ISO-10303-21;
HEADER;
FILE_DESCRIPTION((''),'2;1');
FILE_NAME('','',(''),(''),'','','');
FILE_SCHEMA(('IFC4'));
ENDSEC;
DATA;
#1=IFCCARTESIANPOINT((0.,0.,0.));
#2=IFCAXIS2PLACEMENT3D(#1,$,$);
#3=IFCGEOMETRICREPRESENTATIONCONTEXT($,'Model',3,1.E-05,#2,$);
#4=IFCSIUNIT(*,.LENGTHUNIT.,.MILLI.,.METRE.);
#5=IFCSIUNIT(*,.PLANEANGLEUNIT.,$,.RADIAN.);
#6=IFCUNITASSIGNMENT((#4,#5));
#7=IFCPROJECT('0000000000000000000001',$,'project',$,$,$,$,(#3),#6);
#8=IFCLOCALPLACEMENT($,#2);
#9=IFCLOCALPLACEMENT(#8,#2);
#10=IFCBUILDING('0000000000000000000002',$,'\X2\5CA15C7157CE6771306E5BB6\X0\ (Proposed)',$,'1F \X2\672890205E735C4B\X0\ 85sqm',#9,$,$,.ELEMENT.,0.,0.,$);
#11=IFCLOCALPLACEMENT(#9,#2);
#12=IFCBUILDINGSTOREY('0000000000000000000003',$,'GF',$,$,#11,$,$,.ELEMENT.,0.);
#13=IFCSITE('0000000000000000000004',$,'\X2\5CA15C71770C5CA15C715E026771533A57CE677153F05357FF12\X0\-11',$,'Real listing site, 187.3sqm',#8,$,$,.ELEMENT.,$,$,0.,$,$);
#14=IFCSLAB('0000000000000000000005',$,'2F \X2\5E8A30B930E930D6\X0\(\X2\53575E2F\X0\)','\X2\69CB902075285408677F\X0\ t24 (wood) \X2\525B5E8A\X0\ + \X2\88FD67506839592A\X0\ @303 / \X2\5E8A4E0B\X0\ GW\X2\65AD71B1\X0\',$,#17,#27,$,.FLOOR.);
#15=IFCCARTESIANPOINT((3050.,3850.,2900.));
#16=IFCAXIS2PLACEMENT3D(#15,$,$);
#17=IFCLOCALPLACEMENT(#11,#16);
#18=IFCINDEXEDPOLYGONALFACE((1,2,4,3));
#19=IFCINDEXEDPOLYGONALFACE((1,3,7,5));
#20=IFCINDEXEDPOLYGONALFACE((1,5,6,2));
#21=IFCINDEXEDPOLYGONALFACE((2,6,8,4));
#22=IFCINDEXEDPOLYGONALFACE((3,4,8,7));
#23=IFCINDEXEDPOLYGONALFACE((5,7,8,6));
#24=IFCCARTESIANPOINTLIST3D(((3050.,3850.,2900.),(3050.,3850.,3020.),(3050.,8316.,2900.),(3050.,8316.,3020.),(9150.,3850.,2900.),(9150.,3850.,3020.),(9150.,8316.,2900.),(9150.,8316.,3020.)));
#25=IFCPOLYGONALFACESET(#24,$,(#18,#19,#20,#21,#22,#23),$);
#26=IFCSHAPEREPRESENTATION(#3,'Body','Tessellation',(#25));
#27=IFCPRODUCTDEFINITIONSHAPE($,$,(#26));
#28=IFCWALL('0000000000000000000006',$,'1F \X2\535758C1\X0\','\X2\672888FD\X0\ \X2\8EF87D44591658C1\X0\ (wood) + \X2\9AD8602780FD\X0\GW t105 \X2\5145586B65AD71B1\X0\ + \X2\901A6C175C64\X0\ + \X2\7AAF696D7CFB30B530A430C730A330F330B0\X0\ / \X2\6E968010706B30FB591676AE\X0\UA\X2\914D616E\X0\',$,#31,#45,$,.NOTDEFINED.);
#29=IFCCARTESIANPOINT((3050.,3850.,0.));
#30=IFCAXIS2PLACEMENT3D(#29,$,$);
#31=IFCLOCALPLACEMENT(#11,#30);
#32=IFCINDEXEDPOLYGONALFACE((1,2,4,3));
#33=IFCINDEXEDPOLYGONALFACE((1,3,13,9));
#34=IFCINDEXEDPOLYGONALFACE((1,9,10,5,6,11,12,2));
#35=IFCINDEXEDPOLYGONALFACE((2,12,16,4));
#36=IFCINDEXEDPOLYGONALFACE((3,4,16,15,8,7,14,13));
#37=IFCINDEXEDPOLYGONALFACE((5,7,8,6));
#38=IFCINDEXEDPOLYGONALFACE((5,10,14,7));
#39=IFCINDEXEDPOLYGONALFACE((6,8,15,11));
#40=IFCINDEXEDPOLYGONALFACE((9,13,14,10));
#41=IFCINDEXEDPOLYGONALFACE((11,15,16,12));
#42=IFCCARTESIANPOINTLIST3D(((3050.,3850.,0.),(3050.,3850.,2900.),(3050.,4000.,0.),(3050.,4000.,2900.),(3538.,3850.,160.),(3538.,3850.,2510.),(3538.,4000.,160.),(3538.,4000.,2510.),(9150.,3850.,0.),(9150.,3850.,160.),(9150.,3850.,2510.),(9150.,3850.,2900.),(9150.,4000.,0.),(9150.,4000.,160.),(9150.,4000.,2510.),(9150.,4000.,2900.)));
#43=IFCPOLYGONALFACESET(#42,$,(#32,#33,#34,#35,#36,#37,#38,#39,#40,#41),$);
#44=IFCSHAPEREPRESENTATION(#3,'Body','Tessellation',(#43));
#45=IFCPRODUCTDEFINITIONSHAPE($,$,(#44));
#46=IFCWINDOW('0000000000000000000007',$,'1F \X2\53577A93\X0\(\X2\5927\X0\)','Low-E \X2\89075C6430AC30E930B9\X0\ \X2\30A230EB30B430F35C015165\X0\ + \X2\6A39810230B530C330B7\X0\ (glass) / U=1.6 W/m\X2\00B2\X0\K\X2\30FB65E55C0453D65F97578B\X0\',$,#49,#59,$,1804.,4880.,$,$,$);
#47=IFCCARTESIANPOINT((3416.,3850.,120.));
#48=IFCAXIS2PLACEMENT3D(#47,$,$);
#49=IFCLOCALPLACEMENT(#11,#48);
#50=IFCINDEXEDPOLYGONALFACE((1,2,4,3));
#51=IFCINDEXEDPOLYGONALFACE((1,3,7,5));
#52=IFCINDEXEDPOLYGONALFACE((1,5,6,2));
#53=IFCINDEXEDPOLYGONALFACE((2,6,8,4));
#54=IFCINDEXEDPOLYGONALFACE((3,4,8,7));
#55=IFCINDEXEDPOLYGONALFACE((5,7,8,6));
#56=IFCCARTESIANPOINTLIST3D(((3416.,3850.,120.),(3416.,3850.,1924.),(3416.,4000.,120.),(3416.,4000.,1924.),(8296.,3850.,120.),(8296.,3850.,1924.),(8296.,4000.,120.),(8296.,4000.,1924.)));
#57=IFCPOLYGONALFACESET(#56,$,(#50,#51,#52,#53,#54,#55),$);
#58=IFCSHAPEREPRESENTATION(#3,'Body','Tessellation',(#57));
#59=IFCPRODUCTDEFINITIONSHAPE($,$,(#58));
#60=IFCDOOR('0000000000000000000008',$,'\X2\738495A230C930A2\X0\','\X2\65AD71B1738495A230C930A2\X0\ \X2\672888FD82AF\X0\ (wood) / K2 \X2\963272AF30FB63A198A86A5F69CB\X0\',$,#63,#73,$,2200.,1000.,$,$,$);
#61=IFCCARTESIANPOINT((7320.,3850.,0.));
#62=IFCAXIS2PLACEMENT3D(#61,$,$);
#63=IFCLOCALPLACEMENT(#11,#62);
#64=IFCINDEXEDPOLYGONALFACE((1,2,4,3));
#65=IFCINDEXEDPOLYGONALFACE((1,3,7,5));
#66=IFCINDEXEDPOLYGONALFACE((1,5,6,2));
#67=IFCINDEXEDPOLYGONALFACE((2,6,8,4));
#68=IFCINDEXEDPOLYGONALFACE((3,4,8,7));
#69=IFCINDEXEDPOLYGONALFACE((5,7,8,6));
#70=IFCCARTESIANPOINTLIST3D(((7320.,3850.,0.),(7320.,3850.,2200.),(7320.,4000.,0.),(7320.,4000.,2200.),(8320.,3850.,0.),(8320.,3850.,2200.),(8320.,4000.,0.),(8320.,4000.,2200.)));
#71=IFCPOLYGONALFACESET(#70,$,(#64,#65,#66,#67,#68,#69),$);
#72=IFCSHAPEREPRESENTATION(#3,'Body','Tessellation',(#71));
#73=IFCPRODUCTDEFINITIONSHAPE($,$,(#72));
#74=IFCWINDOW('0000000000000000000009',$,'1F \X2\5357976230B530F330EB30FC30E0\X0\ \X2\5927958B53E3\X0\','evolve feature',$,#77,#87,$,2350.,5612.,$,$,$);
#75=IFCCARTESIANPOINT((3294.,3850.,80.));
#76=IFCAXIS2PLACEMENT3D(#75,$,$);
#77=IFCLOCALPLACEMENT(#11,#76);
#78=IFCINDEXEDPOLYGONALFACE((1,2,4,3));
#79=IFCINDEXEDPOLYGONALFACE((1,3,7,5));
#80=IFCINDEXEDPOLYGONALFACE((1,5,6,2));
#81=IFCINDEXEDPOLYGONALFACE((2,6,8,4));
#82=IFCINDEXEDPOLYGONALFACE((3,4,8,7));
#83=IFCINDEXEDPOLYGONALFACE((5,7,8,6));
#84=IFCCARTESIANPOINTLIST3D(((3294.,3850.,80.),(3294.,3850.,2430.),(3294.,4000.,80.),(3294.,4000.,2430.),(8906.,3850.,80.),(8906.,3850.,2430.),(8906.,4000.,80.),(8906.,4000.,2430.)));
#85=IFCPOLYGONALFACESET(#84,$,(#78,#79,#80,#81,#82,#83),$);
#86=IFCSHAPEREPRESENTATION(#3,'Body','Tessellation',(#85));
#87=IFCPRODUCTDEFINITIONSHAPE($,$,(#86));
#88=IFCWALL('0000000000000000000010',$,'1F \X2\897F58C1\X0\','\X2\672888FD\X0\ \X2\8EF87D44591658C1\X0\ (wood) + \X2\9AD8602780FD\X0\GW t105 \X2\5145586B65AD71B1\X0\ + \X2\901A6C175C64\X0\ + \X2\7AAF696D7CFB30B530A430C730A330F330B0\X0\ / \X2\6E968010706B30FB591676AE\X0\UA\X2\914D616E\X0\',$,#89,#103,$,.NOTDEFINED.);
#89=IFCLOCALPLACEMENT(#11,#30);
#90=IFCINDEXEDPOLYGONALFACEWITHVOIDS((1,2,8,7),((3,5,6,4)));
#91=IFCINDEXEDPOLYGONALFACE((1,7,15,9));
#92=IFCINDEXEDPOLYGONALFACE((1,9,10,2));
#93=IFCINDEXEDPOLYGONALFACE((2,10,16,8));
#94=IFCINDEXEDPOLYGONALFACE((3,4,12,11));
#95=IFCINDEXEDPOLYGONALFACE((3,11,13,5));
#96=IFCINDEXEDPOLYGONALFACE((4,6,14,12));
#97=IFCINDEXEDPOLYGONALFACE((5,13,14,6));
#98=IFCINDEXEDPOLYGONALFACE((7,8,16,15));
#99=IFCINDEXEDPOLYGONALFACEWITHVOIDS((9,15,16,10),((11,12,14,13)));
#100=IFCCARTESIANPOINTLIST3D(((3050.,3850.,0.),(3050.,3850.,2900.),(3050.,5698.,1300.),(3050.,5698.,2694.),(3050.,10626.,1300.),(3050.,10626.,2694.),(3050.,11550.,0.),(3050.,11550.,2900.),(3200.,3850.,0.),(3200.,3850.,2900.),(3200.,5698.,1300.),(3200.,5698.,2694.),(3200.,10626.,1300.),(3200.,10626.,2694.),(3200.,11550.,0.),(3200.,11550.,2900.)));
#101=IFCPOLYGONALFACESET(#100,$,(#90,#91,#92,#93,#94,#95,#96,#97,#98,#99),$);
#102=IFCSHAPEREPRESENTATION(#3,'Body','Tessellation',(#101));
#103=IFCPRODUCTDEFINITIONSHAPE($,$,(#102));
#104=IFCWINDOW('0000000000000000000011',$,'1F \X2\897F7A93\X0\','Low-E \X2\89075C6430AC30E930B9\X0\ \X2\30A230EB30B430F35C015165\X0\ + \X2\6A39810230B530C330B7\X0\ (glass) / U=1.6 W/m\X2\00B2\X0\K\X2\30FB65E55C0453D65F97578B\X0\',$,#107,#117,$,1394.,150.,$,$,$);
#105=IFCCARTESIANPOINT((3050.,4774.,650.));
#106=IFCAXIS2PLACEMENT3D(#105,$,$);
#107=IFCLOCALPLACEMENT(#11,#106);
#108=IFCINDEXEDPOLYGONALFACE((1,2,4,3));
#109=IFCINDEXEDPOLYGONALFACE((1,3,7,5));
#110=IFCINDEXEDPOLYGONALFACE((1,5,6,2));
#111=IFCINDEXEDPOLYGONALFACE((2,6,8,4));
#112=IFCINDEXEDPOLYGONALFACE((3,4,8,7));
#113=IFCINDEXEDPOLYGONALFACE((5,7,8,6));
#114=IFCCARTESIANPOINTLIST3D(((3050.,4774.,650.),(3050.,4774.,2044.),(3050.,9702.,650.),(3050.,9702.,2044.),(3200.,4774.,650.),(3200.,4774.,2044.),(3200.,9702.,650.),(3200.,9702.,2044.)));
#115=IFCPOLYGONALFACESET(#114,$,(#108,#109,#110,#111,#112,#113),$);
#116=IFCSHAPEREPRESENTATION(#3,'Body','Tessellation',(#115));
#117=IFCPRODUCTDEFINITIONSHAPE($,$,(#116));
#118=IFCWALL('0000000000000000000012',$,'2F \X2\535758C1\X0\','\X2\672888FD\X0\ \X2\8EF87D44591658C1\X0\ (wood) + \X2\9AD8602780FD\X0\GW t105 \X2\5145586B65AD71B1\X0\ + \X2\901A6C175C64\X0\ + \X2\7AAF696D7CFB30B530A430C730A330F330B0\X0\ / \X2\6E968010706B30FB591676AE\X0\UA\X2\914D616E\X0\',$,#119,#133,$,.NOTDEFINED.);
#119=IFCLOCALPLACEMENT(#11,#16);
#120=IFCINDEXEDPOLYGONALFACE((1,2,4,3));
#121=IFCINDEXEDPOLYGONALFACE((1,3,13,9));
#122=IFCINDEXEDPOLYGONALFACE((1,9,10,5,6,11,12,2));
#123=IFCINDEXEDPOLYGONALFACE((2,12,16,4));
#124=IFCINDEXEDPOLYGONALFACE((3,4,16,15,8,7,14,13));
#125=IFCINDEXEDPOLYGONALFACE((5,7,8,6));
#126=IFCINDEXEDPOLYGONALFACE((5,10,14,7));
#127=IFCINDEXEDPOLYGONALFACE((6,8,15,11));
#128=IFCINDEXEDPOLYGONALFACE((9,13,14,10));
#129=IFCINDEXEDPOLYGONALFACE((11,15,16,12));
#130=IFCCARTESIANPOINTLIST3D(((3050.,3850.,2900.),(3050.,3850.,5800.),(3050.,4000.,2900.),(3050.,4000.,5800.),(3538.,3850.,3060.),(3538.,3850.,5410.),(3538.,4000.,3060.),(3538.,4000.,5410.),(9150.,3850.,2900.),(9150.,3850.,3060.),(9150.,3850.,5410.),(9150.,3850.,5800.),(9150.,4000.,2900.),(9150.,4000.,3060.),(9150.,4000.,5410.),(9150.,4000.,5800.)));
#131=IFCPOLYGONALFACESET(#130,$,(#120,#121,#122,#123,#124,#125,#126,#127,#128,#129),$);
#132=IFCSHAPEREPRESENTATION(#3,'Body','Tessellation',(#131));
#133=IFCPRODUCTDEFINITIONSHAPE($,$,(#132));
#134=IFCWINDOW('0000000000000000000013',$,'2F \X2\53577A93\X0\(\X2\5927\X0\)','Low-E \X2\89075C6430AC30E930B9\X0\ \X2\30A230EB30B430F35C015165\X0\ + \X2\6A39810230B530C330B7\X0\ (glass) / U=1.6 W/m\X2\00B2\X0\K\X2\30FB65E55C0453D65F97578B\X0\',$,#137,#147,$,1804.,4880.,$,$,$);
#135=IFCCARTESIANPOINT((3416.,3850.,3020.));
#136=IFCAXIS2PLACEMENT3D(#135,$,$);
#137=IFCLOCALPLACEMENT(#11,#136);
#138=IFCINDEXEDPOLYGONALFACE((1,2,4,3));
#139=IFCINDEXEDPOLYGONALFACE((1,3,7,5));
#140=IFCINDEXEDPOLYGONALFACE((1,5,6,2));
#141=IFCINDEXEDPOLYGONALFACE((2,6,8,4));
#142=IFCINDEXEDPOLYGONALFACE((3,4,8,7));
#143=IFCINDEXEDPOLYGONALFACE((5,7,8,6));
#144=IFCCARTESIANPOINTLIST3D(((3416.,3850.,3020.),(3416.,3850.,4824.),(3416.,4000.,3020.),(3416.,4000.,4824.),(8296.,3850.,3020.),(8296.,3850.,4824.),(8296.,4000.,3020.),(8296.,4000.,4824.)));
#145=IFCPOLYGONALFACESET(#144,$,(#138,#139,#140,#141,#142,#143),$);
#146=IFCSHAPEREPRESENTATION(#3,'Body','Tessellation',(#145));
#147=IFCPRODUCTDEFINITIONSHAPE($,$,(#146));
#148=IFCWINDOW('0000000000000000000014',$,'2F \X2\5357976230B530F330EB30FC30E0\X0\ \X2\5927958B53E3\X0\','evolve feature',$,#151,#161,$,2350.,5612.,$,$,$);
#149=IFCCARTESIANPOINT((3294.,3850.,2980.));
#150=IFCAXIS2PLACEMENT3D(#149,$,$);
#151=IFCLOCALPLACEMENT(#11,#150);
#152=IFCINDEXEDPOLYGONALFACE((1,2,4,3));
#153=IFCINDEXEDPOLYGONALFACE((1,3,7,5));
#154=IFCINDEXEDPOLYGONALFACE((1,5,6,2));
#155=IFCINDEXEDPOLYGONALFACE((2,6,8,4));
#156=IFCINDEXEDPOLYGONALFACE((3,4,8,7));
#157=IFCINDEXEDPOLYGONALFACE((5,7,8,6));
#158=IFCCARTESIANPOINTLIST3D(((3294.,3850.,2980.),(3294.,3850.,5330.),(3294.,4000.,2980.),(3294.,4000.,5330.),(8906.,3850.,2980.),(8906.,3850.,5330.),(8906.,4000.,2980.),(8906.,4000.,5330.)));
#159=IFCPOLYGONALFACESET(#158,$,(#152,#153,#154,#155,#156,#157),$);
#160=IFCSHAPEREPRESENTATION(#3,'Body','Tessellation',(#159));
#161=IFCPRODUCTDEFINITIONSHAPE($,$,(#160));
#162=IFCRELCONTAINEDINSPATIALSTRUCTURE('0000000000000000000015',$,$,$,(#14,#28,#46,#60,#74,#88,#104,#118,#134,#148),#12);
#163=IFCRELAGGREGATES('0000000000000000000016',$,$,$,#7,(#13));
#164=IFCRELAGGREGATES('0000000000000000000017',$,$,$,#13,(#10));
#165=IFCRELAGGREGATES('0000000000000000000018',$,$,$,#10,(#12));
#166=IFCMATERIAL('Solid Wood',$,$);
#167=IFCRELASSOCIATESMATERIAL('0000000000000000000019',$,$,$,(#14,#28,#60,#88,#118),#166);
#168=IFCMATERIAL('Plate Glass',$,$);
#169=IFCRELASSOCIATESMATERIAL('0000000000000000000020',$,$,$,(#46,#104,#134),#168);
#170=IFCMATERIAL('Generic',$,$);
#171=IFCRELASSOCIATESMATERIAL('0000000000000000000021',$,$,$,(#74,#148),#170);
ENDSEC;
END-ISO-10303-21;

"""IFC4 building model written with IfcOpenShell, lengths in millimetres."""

from ifc_helpers import new_model, si_unit, frame, frame_2d, origin, place, context, project, spatial, rectangle, extrude, material, element, fill, save


model = new_model("IFC4")

# Units and contexts
model_context = context("Model", 3, precision=1e-05, world=origin())
ifc_project = project(units=[si_unit("LENGTHUNIT", "METRE", prefix="MILLI"), si_unit("PLANEANGLEUNIT", "RADIAN")], contexts=[model_context])

# Site, building, storey
site_placement = place(None, origin())
site = spatial("IfcSite", under=ifc_project, at=site_placement, Name="岡山県岡山市東区城東台南２-11", ObjectType="Real listing site, 187.3sqm", CompositionType="ELEMENT", RefElevation=0.0)
building_placement = place(site_placement, origin())
building = spatial("IfcBuilding", under=site, at=building_placement, Name="岡山城東の家 (Proposed)", ObjectType="1F 木造平屋 85sqm", CompositionType="ELEMENT", ElevationOfRefHeight=0.0, ElevationOfTerrain=0.0)
storey_placement = place(building_placement, origin())
storey = spatial("IfcBuildingStorey", under=building, at=storey_placement, Name="GF", CompositionType="ELEMENT", Elevation=0.0)

# Slab
ifc_material_1 = material(Name="Solid Wood")
slab_1_placement = place(storey_placement, frame((3050.0, 3850.0, 2900.0)))
element("IfcSlab", 1, at=slab_1_placement, inside=storey, material=ifc_material_1, Name="2F 床スラブ(南帯)", Description="構造用合板 t24 (wood) 剛床 + 製材根太 @303 / 床下 GW断熱", PredefinedType="FLOOR", context=model_context, shape_type="SweptSolid", body=[
    extrude(rectangle(XDim=6100.0, YDim=4466.0, at=frame_2d((3050.0, 2233.0))), frame((3050.0, 3850.0, 2900.0)), (0.0, 0.0, 1.0), 120.0),
])
ifc_material_2 = material(Name="Generic")

# Wall, openings, windows, door
wall_1_placement = place(storey_placement, frame((3050.0, 3850.0, 0.0)))
wall_1 = element("IfcWall", 2, at=wall_1_placement, inside=storey, material=ifc_material_1, Name="1F 南壁", Description="木製 軸組外壁 (wood) + 高性能GW t105 充填断熱 + 通気層 + 窯業系サイディング / 準耐火・外皮UA配慮", PredefinedType="NOTDEFINED", context=model_context, shape_type="SweptSolid", body=[
    extrude(rectangle(XDim=6100.0, YDim=150.0, at=frame_2d((3050.0, 75.0))), frame((3050.0, 3850.0, 0.0)), (0.0, 0.0, 1.0), 2900.0),
])
opening_1_placement = place(storey_placement, frame((3416.0, 3850.0, 120.0)))
opening_1 = element("IfcOpeningElement", 3, at=opening_1_placement, cuts=wall_1, PredefinedType="NOTDEFINED", context=model_context, shape_type="SweptSolid", body=[
    extrude(rectangle(XDim=4880.0, YDim=150.0, at=frame_2d((2440.0, 75.0))), frame((3416.0, 3850.0, 120.0)), (0.0, 0.0, 1.0), 1804.0),
])
opening_2_placement = place(storey_placement, frame((7320.0, 3850.0, 0.0)))
opening_2 = element("IfcOpeningElement", 4, at=opening_2_placement, cuts=wall_1, PredefinedType="NOTDEFINED", context=model_context, shape_type="SweptSolid", body=[
    extrude(rectangle(XDim=1000.0, YDim=150.0, at=frame_2d((500.0, 75.0))), frame((7320.0, 3850.0, 0.0)), (0.0, 0.0, 1.0), 2200.0),
])
opening_3_placement = place(storey_placement, frame((3294.0, 3850.0, 80.0)))
opening_3 = element("IfcOpeningElement", 5, at=opening_3_placement, cuts=wall_1, PredefinedType="NOTDEFINED", context=model_context, shape_type="SweptSolid", body=[
    extrude(rectangle(XDim=5612.0, YDim=150.0, at=frame_2d((2806.0, 75.0))), frame((3294.0, 3850.0, 80.0)), (0.0, 0.0, 1.0), 2350.0),
])
ifc_material_3 = material(Name="Plate Glass")
window_1_placement = place(storey_placement, frame((3416.0, 3850.0, 120.0)))
window_1 = element("IfcWindow", 6, at=window_1_placement, inside=storey, material=ifc_material_3, Name="1F 南窓(大)", Description="Low-E 複層ガラス アルゴン封入 + 樹脂サッシ (glass) / U=1.6 W/m²K・日射取得型", OverallHeight=1804.0, OverallWidth=4880.0, context=model_context, shape_type="SweptSolid", body=[
    extrude(rectangle(XDim=4880.0, YDim=150.0, at=frame_2d((2440.0, 75.0))), frame((3416.0, 3850.0, 120.0)), (0.0, 0.0, 1.0), 1804.0),
])
fill(opening_1, window_1)
door_placement = place(storey_placement, frame((7320.0, 3850.0, 0.0)))
door = element("IfcDoor", 7, at=door_placement, inside=storey, material=ifc_material_1, Name="玄関ドア", Description="断熱玄関ドア 木製芯 (wood) / K2 防犯・採風機構", OverallHeight=2200.0, OverallWidth=1000.0, context=model_context, shape_type="SweptSolid", body=[
    extrude(rectangle(XDim=1000.0, YDim=150.0, at=frame_2d((500.0, 75.0))), frame((7320.0, 3850.0, 0.0)), (0.0, 0.0, 1.0), 2200.0),
])
fill(opening_2, door)
window_2_placement = place(storey_placement, frame((3294.0, 3850.0, 80.0)))
window_2 = element("IfcWindow", 8, at=window_2_placement, inside=storey, material=ifc_material_2, Name="1F 南面サンルーム 大開口", Description="evolve feature", OverallHeight=2350.0, OverallWidth=5612.0, context=model_context, shape_type="SweptSolid", body=[
    extrude(rectangle(XDim=5612.0, YDim=150.0, at=frame_2d((2806.0, 75.0))), frame((3294.0, 3850.0, 80.0)), (0.0, 0.0, 1.0), 2350.0),
])
fill(opening_3, window_2)

# Wall, opening, window
wall_2_placement = place(storey_placement, frame((3050.0, 3850.0, 0.0)))
wall_2 = element("IfcWall", 9, at=wall_2_placement, inside=storey, material=ifc_material_1, Name="1F 西壁", Description="木製 軸組外壁 (wood) + 高性能GW t105 充填断熱 + 通気層 + 窯業系サイディング / 準耐火・外皮UA配慮", PredefinedType="NOTDEFINED", context=model_context, shape_type="SweptSolid", body=[
    extrude(rectangle(XDim=150.0, YDim=7700.0, at=frame_2d((75.0, 3850.0))), frame((3050.0, 3850.0, 0.0)), (0.0, 0.0, 1.0), 2900.0),
])
opening_4_placement = place(storey_placement, frame((3050.0, 4774.0, 650.0)))
opening_4 = element("IfcOpeningElement", 10, at=opening_4_placement, cuts=wall_2, PredefinedType="NOTDEFINED", context=model_context, shape_type="SweptSolid", body=[
    extrude(rectangle(XDim=150.0, YDim=4928.0, at=frame_2d((75.0, 2464.0))), frame((3050.0, 4774.0, 650.0)), (0.0, 0.0, 1.0), 1394.0),
])
window_3_placement = place(storey_placement, frame((3050.0, 4774.0, 650.0)))
window_3 = element("IfcWindow", 11, at=window_3_placement, inside=storey, material=ifc_material_3, Name="1F 西窓", Description="Low-E 複層ガラス アルゴン封入 + 樹脂サッシ (glass) / U=1.6 W/m²K・日射取得型", OverallHeight=1394.0, OverallWidth=150.0, context=model_context, shape_type="SweptSolid", body=[
    extrude(rectangle(XDim=150.0, YDim=4928.0, at=frame_2d((75.0, 2464.0))), frame((3050.0, 4774.0, 650.0)), (0.0, 0.0, 1.0), 1394.0),
])
fill(opening_4, window_3)

# Wall, openings, windows
wall_3_placement = place(storey_placement, frame((3050.0, 3850.0, 2900.0)))
wall_3 = element("IfcWall", 12, at=wall_3_placement, inside=storey, material=ifc_material_1, Name="2F 南壁", Description="木製 軸組外壁 (wood) + 高性能GW t105 充填断熱 + 通気層 + 窯業系サイディング / 準耐火・外皮UA配慮", PredefinedType="NOTDEFINED", context=model_context, shape_type="SweptSolid", body=[
    extrude(rectangle(XDim=6100.0, YDim=150.0, at=frame_2d((3050.0, 75.0))), frame((3050.0, 3850.0, 2900.0)), (0.0, 0.0, 1.0), 2900.0),
])
opening_5_placement = place(storey_placement, frame((3416.0, 3850.0, 3020.0)))
opening_5 = element("IfcOpeningElement", 13, at=opening_5_placement, cuts=wall_3, PredefinedType="NOTDEFINED", context=model_context, shape_type="SweptSolid", body=[
    extrude(rectangle(XDim=4880.0, YDim=150.0, at=frame_2d((2440.0, 75.0))), frame((3416.0, 3850.0, 3020.0)), (0.0, 0.0, 1.0), 1804.0),
])
opening_6_placement = place(storey_placement, frame((3294.0, 3850.0, 2980.0)))
opening_6 = element("IfcOpeningElement", 14, at=opening_6_placement, cuts=wall_3, PredefinedType="NOTDEFINED", context=model_context, shape_type="SweptSolid", body=[
    extrude(rectangle(XDim=5612.0, YDim=150.0, at=frame_2d((2806.0, 75.0))), frame((3294.0, 3850.0, 2980.0)), (0.0, 0.0, 1.0), 2350.0),
])
window_4_placement = place(storey_placement, frame((3416.0, 3850.0, 3020.0)))
window_4 = element("IfcWindow", 15, at=window_4_placement, inside=storey, material=ifc_material_3, Name="2F 南窓(大)", Description="Low-E 複層ガラス アルゴン封入 + 樹脂サッシ (glass) / U=1.6 W/m²K・日射取得型", OverallHeight=1804.0, OverallWidth=4880.0, context=model_context, shape_type="SweptSolid", body=[
    extrude(rectangle(XDim=4880.0, YDim=150.0, at=frame_2d((2440.0, 75.0))), frame((3416.0, 3850.0, 3020.0)), (0.0, 0.0, 1.0), 1804.0),
])
fill(opening_5, window_4)
window_5_placement = place(storey_placement, frame((3294.0, 3850.0, 2980.0)))
window_5 = element("IfcWindow", 16, at=window_5_placement, inside=storey, material=ifc_material_2, Name="2F 南面サンルーム 大開口", Description="evolve feature", OverallHeight=2350.0, OverallWidth=5612.0, context=model_context, shape_type="SweptSolid", body=[
    extrude(rectangle(XDim=5612.0, YDim=150.0, at=frame_2d((2806.0, 75.0))), frame((3294.0, 3850.0, 2980.0)), (0.0, 0.0, 1.0), 2350.0),
])
fill(opening_6, window_5)

save(model, "model.ifc")
